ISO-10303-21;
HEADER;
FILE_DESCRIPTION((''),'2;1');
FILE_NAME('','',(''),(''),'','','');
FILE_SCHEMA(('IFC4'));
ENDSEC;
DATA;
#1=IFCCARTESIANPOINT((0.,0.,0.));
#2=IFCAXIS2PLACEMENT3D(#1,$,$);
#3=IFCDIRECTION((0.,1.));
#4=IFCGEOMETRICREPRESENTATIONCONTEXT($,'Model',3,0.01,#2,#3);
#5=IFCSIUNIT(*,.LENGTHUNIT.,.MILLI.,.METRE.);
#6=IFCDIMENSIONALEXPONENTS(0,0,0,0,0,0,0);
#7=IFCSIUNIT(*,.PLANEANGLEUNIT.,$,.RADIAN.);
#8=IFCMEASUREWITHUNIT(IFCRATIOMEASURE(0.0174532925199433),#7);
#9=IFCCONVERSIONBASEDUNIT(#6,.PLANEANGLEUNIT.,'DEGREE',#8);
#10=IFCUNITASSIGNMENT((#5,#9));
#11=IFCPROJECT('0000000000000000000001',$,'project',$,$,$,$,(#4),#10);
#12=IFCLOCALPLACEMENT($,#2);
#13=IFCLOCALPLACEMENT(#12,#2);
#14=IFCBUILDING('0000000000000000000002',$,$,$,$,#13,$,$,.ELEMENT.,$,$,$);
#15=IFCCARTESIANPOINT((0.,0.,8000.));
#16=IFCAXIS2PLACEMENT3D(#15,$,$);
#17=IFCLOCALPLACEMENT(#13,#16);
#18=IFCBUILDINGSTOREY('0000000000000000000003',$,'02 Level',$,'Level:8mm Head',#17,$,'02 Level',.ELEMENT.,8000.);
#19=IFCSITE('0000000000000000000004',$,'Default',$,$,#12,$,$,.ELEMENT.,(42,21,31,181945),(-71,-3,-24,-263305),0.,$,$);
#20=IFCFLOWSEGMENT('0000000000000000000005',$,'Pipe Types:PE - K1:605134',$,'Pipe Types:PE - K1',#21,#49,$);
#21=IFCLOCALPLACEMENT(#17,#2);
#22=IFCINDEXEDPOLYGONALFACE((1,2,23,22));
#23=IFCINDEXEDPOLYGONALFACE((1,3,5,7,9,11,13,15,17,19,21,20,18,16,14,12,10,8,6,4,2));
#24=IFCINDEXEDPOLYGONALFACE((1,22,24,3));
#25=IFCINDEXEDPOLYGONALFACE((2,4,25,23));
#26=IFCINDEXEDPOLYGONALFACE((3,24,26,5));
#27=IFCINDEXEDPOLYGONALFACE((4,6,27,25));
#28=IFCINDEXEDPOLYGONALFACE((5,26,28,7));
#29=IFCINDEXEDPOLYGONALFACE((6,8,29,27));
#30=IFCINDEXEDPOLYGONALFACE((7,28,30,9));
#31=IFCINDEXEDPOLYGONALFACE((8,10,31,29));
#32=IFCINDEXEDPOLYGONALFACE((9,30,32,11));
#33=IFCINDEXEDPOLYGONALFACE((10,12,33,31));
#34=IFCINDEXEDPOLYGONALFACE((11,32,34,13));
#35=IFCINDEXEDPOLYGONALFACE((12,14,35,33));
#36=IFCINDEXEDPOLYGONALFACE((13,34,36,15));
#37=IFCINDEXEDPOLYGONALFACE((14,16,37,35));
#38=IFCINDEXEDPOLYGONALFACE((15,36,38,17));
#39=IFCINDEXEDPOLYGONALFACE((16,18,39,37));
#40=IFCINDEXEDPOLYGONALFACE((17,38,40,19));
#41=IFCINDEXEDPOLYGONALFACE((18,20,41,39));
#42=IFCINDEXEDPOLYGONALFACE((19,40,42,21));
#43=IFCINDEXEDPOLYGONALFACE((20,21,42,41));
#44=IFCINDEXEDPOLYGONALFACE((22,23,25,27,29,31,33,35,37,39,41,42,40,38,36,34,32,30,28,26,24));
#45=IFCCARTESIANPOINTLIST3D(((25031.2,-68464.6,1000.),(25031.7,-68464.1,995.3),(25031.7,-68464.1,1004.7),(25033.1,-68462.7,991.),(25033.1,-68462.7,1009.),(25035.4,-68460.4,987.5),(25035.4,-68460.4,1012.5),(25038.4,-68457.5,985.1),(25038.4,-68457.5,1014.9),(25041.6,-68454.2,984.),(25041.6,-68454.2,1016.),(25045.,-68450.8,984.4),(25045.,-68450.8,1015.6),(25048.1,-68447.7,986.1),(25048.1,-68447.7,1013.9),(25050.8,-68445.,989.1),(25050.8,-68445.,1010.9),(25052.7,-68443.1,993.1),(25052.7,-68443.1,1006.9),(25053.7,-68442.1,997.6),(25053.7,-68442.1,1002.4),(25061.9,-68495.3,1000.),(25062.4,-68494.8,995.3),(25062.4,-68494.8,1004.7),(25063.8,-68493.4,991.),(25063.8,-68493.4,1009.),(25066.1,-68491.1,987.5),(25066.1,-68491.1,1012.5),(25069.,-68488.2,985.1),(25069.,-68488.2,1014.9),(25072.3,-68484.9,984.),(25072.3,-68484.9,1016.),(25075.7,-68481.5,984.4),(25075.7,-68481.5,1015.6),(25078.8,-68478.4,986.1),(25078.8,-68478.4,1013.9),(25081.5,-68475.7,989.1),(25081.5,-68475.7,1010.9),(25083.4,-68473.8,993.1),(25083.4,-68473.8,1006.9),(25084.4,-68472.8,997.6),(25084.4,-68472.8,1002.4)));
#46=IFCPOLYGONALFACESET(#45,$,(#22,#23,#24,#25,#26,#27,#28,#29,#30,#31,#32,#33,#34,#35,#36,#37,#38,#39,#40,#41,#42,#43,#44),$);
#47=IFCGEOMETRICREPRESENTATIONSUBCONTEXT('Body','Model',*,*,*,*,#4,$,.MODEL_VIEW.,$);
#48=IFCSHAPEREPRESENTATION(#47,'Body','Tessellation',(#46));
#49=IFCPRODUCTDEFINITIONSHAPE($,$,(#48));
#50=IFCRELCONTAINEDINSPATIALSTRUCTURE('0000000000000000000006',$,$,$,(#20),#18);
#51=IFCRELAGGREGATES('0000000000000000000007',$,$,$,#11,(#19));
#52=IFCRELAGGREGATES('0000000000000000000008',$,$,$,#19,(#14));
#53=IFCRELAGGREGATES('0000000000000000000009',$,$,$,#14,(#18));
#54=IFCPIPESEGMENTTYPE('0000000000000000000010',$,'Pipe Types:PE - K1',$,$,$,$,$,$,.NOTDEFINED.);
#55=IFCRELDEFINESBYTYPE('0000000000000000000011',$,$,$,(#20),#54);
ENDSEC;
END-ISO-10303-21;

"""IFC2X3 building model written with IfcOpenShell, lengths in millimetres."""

from ifc_helpers import new_model, entity, si_unit, converted_unit, direction, frame, frame_2d, origin, place, context, subcontext, project, spatial, circle, extrude, type_object, element, save


model = new_model("IFC2X3")

# Units and contexts
model_context = context("Model", 3, precision=0.01, world=origin(), true_north=direction((0.0, 1.0)))
body_context = subcontext(model_context, "Body", "Model", "MODEL_VIEW")
ifc_project = project(units=[si_unit("LENGTHUNIT", "METRE", prefix="MILLI"), converted_unit("PLANEANGLEUNIT", "DEGREE", entity("IfcRatioMeasure", 0.0174532925199433), si_unit("PLANEANGLEUNIT", "RADIAN"), dimensions=[0, 0, 0, 0, 0, 0, 0])], contexts=[model_context])

# Site, building, storey
site_placement = place(None, origin())
site = spatial("IfcSite", under=ifc_project, at=site_placement, Name="Default", CompositionType="ELEMENT", RefLatitude=(42, 21, 31, 181945), RefLongitude=(-71, -3, -24, -263305), RefElevation=0.0)
building_placement = place(site_placement, origin())
building = spatial("IfcBuilding", under=site, at=building_placement, CompositionType="ELEMENT")
storey_placement = place(building_placement, frame((0.0, 0.0, 8000.0)))
storey = spatial("IfcBuildingStorey", under=building, at=storey_placement, Name="02 Level", ObjectType="Level:8mm Head", LongName="02 Level", CompositionType="ELEMENT", Elevation=8000.0)

# Flow segment
pipe_segment_type = type_object("IfcPipeSegmentType", Name="Pipe Types:PE - K1", PredefinedType="NOTDEFINED")
flow_segment_1_placement = place(storey_placement, frame((25029.6, -68496.9, 982.4)))
element("IfcFlowSegment", 1, at=flow_segment_1_placement, inside=storey, type_object=pipe_segment_type, Name="Pipe Types:PE - K1:605134", ObjectType="Pipe Types:PE - K1", context=body_context, shape_type="SweptSolid", body=[
    extrude(circle(Radius=16.0, at=frame_2d((0.0, 0.0), x_axis=(1.0, 0.0))), frame((43.6, 12.9, 17.6), z_axis=(-0.707107, 0.707107, 0.0), x_axis=(-0.707107, -0.707107, 0.0)), (0.0, 0.0, 1.0), 43.4),
])

save(model, "model.ifc")
